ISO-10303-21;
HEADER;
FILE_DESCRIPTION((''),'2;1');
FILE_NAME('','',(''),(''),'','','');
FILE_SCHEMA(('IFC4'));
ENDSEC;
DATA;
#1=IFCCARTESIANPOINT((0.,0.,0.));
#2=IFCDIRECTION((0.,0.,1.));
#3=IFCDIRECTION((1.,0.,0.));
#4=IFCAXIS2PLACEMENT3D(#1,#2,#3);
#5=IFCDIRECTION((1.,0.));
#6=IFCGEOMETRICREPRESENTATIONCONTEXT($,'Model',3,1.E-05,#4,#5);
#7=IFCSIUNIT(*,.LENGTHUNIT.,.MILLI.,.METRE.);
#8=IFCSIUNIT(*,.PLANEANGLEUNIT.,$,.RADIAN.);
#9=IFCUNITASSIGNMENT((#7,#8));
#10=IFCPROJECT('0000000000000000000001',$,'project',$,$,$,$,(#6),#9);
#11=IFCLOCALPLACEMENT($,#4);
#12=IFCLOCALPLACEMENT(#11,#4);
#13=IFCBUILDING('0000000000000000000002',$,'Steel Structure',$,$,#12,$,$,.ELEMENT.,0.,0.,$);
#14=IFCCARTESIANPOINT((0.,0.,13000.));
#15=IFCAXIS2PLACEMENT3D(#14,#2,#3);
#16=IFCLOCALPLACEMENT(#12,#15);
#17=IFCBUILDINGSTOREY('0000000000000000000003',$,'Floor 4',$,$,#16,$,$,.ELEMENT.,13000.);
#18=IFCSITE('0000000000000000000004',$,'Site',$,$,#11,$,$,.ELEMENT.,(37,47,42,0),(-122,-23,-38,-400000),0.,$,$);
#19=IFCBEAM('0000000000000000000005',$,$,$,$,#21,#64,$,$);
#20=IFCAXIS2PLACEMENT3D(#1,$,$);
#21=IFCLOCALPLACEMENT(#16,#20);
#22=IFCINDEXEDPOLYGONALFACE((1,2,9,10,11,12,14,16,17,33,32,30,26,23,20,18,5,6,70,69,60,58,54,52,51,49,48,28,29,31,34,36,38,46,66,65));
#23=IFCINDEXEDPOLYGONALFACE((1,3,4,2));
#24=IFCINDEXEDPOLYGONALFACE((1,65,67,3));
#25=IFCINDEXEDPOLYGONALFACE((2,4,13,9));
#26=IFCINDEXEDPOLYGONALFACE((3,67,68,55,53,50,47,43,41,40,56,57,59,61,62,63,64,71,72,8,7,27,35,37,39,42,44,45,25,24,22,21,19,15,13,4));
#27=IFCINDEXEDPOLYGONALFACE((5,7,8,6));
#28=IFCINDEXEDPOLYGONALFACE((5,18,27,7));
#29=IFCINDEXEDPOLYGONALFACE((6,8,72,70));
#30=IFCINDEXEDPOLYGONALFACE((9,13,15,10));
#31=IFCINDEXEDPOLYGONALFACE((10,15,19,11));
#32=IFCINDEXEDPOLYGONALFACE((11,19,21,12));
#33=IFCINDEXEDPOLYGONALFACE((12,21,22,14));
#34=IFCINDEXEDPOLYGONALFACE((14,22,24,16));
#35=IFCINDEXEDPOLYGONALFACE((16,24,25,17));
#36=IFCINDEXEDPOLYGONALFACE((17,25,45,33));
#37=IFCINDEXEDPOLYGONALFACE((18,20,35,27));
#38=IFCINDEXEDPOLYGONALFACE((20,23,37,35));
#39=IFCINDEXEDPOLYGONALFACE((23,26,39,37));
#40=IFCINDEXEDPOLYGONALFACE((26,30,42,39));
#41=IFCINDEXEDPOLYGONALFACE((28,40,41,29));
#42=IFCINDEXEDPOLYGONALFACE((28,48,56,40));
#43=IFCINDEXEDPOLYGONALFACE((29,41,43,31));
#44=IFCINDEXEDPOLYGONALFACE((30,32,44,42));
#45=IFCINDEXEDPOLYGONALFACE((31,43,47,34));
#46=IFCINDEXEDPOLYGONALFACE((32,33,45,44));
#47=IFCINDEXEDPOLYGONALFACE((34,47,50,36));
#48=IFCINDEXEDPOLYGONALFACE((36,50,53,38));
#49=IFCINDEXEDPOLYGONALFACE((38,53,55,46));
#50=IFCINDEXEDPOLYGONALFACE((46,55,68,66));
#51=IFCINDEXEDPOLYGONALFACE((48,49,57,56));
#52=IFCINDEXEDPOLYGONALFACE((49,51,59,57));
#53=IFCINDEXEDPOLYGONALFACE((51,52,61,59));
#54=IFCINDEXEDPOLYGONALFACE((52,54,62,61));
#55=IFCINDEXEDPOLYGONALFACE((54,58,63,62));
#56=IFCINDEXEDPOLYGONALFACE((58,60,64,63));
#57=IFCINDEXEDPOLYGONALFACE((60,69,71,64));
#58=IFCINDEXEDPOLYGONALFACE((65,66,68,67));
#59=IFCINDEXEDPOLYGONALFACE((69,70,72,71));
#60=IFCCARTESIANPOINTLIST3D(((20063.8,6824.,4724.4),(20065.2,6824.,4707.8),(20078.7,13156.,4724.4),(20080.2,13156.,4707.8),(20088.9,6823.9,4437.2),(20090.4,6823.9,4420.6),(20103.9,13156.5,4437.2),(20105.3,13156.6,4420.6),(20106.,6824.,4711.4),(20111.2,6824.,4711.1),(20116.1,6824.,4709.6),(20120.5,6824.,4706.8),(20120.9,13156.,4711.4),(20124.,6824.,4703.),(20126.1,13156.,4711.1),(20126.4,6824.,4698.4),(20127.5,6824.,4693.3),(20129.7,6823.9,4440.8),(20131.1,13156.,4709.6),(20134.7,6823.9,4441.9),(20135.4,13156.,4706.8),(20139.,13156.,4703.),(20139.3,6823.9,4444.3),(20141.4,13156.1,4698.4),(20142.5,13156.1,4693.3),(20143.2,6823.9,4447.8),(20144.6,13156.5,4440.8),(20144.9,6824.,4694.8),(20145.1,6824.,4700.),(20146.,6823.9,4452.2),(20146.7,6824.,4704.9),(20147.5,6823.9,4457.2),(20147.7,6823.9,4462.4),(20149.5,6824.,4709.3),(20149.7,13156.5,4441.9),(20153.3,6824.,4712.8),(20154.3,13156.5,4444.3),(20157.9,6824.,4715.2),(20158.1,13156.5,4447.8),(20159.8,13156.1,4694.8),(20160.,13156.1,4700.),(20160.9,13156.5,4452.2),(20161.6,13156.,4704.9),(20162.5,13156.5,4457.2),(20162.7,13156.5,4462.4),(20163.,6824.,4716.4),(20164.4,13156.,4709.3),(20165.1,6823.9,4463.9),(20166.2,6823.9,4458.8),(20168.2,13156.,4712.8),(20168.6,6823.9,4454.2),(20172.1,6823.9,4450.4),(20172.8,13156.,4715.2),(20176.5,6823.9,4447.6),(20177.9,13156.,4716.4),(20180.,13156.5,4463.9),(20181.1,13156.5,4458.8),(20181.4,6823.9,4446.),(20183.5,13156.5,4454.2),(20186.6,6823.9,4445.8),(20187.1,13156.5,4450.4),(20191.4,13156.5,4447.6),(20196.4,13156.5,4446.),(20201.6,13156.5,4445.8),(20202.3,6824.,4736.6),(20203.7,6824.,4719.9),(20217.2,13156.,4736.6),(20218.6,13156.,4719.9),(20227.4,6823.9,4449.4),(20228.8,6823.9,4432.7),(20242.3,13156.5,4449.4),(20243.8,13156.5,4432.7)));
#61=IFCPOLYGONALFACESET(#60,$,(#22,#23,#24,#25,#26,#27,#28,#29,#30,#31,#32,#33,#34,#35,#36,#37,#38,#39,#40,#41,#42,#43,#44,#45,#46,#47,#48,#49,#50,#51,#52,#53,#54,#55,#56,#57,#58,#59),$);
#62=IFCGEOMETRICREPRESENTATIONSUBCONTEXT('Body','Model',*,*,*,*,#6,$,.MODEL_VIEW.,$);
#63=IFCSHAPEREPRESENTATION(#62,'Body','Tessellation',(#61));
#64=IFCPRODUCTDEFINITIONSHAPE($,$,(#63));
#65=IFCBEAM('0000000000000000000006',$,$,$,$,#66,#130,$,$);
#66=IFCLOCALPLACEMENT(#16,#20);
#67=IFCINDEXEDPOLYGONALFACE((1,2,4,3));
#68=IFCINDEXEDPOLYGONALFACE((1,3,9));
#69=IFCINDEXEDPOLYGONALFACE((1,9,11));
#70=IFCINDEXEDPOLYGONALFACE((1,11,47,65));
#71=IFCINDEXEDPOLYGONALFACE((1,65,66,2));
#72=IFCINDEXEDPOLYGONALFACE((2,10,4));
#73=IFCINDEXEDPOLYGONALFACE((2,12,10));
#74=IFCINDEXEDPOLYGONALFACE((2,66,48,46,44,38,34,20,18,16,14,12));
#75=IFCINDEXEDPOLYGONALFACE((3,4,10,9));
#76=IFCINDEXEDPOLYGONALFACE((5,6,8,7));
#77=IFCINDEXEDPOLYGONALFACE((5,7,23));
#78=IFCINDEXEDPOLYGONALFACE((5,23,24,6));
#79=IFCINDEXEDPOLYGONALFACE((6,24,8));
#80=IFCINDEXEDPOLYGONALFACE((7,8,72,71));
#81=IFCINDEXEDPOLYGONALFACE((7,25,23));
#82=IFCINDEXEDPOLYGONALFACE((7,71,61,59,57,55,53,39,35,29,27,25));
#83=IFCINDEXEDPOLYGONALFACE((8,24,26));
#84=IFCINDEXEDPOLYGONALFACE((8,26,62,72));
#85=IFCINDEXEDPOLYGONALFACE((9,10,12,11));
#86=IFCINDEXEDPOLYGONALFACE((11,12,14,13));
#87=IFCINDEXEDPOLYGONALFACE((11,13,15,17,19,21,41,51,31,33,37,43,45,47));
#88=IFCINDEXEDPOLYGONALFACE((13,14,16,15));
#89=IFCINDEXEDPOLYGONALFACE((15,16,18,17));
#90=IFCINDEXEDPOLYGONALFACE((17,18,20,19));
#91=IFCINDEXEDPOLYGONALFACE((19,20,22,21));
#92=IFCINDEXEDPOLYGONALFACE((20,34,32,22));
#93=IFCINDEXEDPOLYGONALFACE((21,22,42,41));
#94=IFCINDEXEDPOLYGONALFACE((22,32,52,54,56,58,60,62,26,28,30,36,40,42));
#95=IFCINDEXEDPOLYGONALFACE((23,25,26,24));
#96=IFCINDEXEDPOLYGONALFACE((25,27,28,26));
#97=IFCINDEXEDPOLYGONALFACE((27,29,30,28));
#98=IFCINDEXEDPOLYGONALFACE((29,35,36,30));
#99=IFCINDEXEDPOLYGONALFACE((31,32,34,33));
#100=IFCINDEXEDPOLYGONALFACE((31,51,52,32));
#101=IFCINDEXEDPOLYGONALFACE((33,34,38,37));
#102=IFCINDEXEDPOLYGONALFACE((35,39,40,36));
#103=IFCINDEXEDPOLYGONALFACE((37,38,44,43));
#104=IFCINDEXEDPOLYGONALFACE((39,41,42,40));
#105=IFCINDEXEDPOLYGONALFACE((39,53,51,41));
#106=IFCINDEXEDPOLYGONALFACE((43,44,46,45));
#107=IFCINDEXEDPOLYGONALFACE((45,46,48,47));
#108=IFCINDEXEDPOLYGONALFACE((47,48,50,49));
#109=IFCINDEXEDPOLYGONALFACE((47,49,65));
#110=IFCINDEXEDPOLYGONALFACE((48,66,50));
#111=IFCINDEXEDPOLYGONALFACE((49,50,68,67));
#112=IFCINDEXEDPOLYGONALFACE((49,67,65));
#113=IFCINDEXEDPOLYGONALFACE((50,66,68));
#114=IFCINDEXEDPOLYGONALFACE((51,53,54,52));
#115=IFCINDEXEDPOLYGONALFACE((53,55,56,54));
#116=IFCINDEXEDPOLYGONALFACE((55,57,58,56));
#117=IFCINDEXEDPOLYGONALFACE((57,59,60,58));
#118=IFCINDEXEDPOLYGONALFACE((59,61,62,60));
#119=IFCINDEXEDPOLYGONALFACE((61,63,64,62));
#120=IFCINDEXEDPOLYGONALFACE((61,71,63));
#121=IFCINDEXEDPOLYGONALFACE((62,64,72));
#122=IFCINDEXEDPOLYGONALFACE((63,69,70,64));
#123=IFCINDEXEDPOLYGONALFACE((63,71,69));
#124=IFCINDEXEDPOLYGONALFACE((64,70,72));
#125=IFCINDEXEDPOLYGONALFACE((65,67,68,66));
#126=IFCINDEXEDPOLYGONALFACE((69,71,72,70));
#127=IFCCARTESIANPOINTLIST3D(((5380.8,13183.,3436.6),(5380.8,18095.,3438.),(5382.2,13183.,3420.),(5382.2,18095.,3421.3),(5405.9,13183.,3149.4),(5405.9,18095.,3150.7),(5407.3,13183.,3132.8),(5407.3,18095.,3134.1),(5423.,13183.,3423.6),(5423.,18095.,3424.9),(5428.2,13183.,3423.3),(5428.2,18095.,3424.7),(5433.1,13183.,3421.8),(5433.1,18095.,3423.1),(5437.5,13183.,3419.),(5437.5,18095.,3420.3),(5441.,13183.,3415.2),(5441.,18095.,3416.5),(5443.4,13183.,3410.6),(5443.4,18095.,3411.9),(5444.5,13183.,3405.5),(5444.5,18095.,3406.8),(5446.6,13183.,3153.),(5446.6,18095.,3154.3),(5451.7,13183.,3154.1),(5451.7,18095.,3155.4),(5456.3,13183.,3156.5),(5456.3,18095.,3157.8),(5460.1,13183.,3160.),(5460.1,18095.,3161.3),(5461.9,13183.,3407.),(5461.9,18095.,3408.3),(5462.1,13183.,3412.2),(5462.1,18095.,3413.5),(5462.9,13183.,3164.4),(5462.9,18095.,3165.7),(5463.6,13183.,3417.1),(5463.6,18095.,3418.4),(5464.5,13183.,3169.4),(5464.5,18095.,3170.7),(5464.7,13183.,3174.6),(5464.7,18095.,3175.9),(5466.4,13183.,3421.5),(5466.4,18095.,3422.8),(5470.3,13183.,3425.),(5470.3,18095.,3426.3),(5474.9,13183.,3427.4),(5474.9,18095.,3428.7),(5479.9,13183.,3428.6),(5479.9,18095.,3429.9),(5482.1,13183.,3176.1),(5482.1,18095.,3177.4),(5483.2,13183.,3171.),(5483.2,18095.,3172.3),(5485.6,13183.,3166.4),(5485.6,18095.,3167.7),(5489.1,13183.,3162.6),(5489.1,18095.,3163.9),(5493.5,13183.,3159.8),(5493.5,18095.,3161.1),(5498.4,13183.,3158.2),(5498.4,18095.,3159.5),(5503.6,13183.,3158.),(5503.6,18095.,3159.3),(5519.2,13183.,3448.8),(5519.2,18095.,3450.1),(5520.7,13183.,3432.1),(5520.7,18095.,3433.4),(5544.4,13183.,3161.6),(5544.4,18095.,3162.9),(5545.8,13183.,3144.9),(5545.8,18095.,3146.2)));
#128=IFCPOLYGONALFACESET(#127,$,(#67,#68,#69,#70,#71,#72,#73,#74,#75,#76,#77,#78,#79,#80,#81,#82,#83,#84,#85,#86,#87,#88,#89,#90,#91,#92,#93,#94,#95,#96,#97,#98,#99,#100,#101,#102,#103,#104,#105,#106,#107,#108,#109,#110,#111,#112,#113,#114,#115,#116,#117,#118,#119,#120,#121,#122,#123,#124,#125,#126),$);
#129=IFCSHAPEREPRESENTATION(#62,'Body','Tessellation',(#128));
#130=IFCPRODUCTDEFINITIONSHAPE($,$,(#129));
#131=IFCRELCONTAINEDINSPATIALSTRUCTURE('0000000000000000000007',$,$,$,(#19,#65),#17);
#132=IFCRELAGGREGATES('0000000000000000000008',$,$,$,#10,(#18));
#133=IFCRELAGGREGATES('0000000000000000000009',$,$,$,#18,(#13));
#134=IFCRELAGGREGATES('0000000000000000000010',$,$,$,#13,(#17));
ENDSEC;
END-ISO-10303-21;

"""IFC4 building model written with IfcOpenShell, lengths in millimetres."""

from ifc_helpers import new_model, si_unit, direction, frame, origin_with_axes, origin_2d_with_axis, place, context, subcontext, project, spatial, polyline, i_section, extrude, clip, bounded_halfspace, element, save


model = new_model("IFC4")

# Units and contexts
model_context = context("Model", 3, precision=1e-05, world=origin_with_axes(), true_north=direction((1.0, 0.0)))
body_context = subcontext(model_context, "Body", "Model", "MODEL_VIEW")
ifc_project = project(units=[si_unit("LENGTHUNIT", "METRE", prefix="MILLI"), si_unit("PLANEANGLEUNIT", "RADIAN")], contexts=[model_context])

# Site, building, storey
site_placement = place(None, origin_with_axes())
site = spatial("IfcSite", under=ifc_project, at=site_placement, Name="Site", CompositionType="ELEMENT", RefLatitude=(37, 47, 42, 0), RefLongitude=(-122, -23, -38, -400000), RefElevation=0.0)
building_placement = place(site_placement, origin_with_axes())
building = spatial("IfcBuilding", under=site, at=building_placement, Name="Steel Structure", CompositionType="ELEMENT", ElevationOfRefHeight=0.0, ElevationOfTerrain=0.0)
storey_placement = place(building_placement, frame((0.0, 0.0, 13000.0), z_axis=(0.0, 0.0, 1.0), x_axis=(1.0, 0.0, 0.0)))
storey = spatial("IfcBuildingStorey", under=building, at=storey_placement, Name="Floor 4", CompositionType="ELEMENT", Elevation=13000.0)

# Beams
beam_1_placement = place(storey_placement, frame((20159.6, 6823.8, 4426.7), z_axis=(0.002359, 0.999997, 0.0), x_axis=(-0.996192, 0.00235, -0.087156)))
element("IfcBeam", 1, at=beam_1_placement, inside=storey, context=body_context, shape_type="Clipping", body=[
    clip(clip(extrude(i_section(OverallWidth=139.0, OverallDepth=305.0, WebThickness=17.4, FlangeThickness=16.7, FilletRadius=19.9, at=origin_2d_with_axis()), frame((0.0, 152.5, 0.0), z_axis=(0.0, 0.0, 1.0), x_axis=(1.0, 0.0, 0.0)), (0.0, 0.0, 1.0), 6332.9), bounded_halfspace(frame((21601.7, -15604.7, -50.8), z_axis=(-0.002359, 0.0, -0.999997), x_axis=(-0.996192, -0.087156, 0.00235)), False, frame((0.0, 152.5, 0.0), z_axis=(0.0, 0.0, 1.0), x_axis=(1.0, 0.0, 0.0)), polyline([(-69.5, -152.5), (-69.5, -135.8), (-28.6, -135.8), (-8.7, -115.9), (-8.7, 115.9), (-28.6, 135.8), (-69.5, 135.8), (-69.5, 152.5), (69.5, 152.5), (69.5, 135.8), (28.6, 135.8), (8.7, 115.9), (8.7, -115.9), (28.6, -135.8), (69.5, -135.8), (69.5, -152.5), (-69.5, -152.5)]))), bounded_halfspace(frame((21614.5, -15578.3, 6316.7), z_axis=(0.002192, 0.002006, 0.999996), x_axis=(0.996192, 0.087156, -0.002359)), False, frame((0.0, 152.5, 0.0), z_axis=(0.0, 0.0, 1.0), x_axis=(1.0, 0.0, 0.0)), polyline([(69.5, -152.5), (69.5, -135.8), (28.6, -135.8), (8.7, -115.9), (8.7, 115.9), (28.6, 135.8), (69.5, 135.8), (69.5, 152.5), (-69.5, 152.5), (-69.5, 135.8), (-28.6, 135.8), (-8.7, 115.9), (-8.7, -115.9), (-28.6, -135.8), (-69.5, -135.8), (-69.5, -152.5), (69.5, -152.5)]))),
])
beam_2_placement = place(storey_placement, frame((5463.3, 18095.0, 3292.1), z_axis=(0.0, -1.0, -0.000266), x_axis=(-0.996195, 0.000023, -0.087156)))
element("IfcBeam", 2, at=beam_2_placement, inside=storey, context=body_context, shape_type="Clipping", body=[
    clip(clip(extrude(i_section(OverallWidth=139.0, OverallDepth=305.0, WebThickness=17.4, FlangeThickness=16.7, FilletRadius=19.9, at=origin_2d_with_axis()), origin_with_axes(), (0.0, 0.0, 1.0), 4912.1), bounded_halfspace(frame((6862.0, 15752.6, 4916.2), z_axis=(0.0, -0.000266, 1.0), x_axis=(-0.996195, 0.087156, 0.000023)), False, origin_with_axes(), polyline([(-69.5, -135.8), (-69.5, -152.5), (69.5, -152.5), (69.5, -135.8), (28.6, -135.8), (8.7, -115.9), (8.7, 115.9), (28.6, 135.8), (69.5, 135.8), (69.5, 152.5), (-69.5, 152.5), (-69.5, 135.8), (-28.6, 135.8), (-8.7, 115.9), (-8.7, -115.9), (-28.6, -135.8), (-69.5, -135.8)]))), bounded_halfspace(frame((6862.5, 15753.9, 4.4), z_axis=(0.000023, 0.000265, -1.0), x_axis=(0.996195, -0.087156, 0.0)), False, origin_with_axes(), polyline([(-69.5, -152.5), (-69.5, -135.8), (-28.6, -135.8), (-8.7, -115.9), (-8.7, 115.9), (-28.6, 135.8), (-69.5, 135.8), (-69.5, 152.5), (69.5, 152.5), (69.5, 135.8), (28.6, 135.8), (8.7, 115.9), (8.7, -115.9), (28.6, -135.8), (69.5, -135.8), (69.5, -152.5), (-69.5, -152.5)]))),
])

save(model, "model.ifc")
